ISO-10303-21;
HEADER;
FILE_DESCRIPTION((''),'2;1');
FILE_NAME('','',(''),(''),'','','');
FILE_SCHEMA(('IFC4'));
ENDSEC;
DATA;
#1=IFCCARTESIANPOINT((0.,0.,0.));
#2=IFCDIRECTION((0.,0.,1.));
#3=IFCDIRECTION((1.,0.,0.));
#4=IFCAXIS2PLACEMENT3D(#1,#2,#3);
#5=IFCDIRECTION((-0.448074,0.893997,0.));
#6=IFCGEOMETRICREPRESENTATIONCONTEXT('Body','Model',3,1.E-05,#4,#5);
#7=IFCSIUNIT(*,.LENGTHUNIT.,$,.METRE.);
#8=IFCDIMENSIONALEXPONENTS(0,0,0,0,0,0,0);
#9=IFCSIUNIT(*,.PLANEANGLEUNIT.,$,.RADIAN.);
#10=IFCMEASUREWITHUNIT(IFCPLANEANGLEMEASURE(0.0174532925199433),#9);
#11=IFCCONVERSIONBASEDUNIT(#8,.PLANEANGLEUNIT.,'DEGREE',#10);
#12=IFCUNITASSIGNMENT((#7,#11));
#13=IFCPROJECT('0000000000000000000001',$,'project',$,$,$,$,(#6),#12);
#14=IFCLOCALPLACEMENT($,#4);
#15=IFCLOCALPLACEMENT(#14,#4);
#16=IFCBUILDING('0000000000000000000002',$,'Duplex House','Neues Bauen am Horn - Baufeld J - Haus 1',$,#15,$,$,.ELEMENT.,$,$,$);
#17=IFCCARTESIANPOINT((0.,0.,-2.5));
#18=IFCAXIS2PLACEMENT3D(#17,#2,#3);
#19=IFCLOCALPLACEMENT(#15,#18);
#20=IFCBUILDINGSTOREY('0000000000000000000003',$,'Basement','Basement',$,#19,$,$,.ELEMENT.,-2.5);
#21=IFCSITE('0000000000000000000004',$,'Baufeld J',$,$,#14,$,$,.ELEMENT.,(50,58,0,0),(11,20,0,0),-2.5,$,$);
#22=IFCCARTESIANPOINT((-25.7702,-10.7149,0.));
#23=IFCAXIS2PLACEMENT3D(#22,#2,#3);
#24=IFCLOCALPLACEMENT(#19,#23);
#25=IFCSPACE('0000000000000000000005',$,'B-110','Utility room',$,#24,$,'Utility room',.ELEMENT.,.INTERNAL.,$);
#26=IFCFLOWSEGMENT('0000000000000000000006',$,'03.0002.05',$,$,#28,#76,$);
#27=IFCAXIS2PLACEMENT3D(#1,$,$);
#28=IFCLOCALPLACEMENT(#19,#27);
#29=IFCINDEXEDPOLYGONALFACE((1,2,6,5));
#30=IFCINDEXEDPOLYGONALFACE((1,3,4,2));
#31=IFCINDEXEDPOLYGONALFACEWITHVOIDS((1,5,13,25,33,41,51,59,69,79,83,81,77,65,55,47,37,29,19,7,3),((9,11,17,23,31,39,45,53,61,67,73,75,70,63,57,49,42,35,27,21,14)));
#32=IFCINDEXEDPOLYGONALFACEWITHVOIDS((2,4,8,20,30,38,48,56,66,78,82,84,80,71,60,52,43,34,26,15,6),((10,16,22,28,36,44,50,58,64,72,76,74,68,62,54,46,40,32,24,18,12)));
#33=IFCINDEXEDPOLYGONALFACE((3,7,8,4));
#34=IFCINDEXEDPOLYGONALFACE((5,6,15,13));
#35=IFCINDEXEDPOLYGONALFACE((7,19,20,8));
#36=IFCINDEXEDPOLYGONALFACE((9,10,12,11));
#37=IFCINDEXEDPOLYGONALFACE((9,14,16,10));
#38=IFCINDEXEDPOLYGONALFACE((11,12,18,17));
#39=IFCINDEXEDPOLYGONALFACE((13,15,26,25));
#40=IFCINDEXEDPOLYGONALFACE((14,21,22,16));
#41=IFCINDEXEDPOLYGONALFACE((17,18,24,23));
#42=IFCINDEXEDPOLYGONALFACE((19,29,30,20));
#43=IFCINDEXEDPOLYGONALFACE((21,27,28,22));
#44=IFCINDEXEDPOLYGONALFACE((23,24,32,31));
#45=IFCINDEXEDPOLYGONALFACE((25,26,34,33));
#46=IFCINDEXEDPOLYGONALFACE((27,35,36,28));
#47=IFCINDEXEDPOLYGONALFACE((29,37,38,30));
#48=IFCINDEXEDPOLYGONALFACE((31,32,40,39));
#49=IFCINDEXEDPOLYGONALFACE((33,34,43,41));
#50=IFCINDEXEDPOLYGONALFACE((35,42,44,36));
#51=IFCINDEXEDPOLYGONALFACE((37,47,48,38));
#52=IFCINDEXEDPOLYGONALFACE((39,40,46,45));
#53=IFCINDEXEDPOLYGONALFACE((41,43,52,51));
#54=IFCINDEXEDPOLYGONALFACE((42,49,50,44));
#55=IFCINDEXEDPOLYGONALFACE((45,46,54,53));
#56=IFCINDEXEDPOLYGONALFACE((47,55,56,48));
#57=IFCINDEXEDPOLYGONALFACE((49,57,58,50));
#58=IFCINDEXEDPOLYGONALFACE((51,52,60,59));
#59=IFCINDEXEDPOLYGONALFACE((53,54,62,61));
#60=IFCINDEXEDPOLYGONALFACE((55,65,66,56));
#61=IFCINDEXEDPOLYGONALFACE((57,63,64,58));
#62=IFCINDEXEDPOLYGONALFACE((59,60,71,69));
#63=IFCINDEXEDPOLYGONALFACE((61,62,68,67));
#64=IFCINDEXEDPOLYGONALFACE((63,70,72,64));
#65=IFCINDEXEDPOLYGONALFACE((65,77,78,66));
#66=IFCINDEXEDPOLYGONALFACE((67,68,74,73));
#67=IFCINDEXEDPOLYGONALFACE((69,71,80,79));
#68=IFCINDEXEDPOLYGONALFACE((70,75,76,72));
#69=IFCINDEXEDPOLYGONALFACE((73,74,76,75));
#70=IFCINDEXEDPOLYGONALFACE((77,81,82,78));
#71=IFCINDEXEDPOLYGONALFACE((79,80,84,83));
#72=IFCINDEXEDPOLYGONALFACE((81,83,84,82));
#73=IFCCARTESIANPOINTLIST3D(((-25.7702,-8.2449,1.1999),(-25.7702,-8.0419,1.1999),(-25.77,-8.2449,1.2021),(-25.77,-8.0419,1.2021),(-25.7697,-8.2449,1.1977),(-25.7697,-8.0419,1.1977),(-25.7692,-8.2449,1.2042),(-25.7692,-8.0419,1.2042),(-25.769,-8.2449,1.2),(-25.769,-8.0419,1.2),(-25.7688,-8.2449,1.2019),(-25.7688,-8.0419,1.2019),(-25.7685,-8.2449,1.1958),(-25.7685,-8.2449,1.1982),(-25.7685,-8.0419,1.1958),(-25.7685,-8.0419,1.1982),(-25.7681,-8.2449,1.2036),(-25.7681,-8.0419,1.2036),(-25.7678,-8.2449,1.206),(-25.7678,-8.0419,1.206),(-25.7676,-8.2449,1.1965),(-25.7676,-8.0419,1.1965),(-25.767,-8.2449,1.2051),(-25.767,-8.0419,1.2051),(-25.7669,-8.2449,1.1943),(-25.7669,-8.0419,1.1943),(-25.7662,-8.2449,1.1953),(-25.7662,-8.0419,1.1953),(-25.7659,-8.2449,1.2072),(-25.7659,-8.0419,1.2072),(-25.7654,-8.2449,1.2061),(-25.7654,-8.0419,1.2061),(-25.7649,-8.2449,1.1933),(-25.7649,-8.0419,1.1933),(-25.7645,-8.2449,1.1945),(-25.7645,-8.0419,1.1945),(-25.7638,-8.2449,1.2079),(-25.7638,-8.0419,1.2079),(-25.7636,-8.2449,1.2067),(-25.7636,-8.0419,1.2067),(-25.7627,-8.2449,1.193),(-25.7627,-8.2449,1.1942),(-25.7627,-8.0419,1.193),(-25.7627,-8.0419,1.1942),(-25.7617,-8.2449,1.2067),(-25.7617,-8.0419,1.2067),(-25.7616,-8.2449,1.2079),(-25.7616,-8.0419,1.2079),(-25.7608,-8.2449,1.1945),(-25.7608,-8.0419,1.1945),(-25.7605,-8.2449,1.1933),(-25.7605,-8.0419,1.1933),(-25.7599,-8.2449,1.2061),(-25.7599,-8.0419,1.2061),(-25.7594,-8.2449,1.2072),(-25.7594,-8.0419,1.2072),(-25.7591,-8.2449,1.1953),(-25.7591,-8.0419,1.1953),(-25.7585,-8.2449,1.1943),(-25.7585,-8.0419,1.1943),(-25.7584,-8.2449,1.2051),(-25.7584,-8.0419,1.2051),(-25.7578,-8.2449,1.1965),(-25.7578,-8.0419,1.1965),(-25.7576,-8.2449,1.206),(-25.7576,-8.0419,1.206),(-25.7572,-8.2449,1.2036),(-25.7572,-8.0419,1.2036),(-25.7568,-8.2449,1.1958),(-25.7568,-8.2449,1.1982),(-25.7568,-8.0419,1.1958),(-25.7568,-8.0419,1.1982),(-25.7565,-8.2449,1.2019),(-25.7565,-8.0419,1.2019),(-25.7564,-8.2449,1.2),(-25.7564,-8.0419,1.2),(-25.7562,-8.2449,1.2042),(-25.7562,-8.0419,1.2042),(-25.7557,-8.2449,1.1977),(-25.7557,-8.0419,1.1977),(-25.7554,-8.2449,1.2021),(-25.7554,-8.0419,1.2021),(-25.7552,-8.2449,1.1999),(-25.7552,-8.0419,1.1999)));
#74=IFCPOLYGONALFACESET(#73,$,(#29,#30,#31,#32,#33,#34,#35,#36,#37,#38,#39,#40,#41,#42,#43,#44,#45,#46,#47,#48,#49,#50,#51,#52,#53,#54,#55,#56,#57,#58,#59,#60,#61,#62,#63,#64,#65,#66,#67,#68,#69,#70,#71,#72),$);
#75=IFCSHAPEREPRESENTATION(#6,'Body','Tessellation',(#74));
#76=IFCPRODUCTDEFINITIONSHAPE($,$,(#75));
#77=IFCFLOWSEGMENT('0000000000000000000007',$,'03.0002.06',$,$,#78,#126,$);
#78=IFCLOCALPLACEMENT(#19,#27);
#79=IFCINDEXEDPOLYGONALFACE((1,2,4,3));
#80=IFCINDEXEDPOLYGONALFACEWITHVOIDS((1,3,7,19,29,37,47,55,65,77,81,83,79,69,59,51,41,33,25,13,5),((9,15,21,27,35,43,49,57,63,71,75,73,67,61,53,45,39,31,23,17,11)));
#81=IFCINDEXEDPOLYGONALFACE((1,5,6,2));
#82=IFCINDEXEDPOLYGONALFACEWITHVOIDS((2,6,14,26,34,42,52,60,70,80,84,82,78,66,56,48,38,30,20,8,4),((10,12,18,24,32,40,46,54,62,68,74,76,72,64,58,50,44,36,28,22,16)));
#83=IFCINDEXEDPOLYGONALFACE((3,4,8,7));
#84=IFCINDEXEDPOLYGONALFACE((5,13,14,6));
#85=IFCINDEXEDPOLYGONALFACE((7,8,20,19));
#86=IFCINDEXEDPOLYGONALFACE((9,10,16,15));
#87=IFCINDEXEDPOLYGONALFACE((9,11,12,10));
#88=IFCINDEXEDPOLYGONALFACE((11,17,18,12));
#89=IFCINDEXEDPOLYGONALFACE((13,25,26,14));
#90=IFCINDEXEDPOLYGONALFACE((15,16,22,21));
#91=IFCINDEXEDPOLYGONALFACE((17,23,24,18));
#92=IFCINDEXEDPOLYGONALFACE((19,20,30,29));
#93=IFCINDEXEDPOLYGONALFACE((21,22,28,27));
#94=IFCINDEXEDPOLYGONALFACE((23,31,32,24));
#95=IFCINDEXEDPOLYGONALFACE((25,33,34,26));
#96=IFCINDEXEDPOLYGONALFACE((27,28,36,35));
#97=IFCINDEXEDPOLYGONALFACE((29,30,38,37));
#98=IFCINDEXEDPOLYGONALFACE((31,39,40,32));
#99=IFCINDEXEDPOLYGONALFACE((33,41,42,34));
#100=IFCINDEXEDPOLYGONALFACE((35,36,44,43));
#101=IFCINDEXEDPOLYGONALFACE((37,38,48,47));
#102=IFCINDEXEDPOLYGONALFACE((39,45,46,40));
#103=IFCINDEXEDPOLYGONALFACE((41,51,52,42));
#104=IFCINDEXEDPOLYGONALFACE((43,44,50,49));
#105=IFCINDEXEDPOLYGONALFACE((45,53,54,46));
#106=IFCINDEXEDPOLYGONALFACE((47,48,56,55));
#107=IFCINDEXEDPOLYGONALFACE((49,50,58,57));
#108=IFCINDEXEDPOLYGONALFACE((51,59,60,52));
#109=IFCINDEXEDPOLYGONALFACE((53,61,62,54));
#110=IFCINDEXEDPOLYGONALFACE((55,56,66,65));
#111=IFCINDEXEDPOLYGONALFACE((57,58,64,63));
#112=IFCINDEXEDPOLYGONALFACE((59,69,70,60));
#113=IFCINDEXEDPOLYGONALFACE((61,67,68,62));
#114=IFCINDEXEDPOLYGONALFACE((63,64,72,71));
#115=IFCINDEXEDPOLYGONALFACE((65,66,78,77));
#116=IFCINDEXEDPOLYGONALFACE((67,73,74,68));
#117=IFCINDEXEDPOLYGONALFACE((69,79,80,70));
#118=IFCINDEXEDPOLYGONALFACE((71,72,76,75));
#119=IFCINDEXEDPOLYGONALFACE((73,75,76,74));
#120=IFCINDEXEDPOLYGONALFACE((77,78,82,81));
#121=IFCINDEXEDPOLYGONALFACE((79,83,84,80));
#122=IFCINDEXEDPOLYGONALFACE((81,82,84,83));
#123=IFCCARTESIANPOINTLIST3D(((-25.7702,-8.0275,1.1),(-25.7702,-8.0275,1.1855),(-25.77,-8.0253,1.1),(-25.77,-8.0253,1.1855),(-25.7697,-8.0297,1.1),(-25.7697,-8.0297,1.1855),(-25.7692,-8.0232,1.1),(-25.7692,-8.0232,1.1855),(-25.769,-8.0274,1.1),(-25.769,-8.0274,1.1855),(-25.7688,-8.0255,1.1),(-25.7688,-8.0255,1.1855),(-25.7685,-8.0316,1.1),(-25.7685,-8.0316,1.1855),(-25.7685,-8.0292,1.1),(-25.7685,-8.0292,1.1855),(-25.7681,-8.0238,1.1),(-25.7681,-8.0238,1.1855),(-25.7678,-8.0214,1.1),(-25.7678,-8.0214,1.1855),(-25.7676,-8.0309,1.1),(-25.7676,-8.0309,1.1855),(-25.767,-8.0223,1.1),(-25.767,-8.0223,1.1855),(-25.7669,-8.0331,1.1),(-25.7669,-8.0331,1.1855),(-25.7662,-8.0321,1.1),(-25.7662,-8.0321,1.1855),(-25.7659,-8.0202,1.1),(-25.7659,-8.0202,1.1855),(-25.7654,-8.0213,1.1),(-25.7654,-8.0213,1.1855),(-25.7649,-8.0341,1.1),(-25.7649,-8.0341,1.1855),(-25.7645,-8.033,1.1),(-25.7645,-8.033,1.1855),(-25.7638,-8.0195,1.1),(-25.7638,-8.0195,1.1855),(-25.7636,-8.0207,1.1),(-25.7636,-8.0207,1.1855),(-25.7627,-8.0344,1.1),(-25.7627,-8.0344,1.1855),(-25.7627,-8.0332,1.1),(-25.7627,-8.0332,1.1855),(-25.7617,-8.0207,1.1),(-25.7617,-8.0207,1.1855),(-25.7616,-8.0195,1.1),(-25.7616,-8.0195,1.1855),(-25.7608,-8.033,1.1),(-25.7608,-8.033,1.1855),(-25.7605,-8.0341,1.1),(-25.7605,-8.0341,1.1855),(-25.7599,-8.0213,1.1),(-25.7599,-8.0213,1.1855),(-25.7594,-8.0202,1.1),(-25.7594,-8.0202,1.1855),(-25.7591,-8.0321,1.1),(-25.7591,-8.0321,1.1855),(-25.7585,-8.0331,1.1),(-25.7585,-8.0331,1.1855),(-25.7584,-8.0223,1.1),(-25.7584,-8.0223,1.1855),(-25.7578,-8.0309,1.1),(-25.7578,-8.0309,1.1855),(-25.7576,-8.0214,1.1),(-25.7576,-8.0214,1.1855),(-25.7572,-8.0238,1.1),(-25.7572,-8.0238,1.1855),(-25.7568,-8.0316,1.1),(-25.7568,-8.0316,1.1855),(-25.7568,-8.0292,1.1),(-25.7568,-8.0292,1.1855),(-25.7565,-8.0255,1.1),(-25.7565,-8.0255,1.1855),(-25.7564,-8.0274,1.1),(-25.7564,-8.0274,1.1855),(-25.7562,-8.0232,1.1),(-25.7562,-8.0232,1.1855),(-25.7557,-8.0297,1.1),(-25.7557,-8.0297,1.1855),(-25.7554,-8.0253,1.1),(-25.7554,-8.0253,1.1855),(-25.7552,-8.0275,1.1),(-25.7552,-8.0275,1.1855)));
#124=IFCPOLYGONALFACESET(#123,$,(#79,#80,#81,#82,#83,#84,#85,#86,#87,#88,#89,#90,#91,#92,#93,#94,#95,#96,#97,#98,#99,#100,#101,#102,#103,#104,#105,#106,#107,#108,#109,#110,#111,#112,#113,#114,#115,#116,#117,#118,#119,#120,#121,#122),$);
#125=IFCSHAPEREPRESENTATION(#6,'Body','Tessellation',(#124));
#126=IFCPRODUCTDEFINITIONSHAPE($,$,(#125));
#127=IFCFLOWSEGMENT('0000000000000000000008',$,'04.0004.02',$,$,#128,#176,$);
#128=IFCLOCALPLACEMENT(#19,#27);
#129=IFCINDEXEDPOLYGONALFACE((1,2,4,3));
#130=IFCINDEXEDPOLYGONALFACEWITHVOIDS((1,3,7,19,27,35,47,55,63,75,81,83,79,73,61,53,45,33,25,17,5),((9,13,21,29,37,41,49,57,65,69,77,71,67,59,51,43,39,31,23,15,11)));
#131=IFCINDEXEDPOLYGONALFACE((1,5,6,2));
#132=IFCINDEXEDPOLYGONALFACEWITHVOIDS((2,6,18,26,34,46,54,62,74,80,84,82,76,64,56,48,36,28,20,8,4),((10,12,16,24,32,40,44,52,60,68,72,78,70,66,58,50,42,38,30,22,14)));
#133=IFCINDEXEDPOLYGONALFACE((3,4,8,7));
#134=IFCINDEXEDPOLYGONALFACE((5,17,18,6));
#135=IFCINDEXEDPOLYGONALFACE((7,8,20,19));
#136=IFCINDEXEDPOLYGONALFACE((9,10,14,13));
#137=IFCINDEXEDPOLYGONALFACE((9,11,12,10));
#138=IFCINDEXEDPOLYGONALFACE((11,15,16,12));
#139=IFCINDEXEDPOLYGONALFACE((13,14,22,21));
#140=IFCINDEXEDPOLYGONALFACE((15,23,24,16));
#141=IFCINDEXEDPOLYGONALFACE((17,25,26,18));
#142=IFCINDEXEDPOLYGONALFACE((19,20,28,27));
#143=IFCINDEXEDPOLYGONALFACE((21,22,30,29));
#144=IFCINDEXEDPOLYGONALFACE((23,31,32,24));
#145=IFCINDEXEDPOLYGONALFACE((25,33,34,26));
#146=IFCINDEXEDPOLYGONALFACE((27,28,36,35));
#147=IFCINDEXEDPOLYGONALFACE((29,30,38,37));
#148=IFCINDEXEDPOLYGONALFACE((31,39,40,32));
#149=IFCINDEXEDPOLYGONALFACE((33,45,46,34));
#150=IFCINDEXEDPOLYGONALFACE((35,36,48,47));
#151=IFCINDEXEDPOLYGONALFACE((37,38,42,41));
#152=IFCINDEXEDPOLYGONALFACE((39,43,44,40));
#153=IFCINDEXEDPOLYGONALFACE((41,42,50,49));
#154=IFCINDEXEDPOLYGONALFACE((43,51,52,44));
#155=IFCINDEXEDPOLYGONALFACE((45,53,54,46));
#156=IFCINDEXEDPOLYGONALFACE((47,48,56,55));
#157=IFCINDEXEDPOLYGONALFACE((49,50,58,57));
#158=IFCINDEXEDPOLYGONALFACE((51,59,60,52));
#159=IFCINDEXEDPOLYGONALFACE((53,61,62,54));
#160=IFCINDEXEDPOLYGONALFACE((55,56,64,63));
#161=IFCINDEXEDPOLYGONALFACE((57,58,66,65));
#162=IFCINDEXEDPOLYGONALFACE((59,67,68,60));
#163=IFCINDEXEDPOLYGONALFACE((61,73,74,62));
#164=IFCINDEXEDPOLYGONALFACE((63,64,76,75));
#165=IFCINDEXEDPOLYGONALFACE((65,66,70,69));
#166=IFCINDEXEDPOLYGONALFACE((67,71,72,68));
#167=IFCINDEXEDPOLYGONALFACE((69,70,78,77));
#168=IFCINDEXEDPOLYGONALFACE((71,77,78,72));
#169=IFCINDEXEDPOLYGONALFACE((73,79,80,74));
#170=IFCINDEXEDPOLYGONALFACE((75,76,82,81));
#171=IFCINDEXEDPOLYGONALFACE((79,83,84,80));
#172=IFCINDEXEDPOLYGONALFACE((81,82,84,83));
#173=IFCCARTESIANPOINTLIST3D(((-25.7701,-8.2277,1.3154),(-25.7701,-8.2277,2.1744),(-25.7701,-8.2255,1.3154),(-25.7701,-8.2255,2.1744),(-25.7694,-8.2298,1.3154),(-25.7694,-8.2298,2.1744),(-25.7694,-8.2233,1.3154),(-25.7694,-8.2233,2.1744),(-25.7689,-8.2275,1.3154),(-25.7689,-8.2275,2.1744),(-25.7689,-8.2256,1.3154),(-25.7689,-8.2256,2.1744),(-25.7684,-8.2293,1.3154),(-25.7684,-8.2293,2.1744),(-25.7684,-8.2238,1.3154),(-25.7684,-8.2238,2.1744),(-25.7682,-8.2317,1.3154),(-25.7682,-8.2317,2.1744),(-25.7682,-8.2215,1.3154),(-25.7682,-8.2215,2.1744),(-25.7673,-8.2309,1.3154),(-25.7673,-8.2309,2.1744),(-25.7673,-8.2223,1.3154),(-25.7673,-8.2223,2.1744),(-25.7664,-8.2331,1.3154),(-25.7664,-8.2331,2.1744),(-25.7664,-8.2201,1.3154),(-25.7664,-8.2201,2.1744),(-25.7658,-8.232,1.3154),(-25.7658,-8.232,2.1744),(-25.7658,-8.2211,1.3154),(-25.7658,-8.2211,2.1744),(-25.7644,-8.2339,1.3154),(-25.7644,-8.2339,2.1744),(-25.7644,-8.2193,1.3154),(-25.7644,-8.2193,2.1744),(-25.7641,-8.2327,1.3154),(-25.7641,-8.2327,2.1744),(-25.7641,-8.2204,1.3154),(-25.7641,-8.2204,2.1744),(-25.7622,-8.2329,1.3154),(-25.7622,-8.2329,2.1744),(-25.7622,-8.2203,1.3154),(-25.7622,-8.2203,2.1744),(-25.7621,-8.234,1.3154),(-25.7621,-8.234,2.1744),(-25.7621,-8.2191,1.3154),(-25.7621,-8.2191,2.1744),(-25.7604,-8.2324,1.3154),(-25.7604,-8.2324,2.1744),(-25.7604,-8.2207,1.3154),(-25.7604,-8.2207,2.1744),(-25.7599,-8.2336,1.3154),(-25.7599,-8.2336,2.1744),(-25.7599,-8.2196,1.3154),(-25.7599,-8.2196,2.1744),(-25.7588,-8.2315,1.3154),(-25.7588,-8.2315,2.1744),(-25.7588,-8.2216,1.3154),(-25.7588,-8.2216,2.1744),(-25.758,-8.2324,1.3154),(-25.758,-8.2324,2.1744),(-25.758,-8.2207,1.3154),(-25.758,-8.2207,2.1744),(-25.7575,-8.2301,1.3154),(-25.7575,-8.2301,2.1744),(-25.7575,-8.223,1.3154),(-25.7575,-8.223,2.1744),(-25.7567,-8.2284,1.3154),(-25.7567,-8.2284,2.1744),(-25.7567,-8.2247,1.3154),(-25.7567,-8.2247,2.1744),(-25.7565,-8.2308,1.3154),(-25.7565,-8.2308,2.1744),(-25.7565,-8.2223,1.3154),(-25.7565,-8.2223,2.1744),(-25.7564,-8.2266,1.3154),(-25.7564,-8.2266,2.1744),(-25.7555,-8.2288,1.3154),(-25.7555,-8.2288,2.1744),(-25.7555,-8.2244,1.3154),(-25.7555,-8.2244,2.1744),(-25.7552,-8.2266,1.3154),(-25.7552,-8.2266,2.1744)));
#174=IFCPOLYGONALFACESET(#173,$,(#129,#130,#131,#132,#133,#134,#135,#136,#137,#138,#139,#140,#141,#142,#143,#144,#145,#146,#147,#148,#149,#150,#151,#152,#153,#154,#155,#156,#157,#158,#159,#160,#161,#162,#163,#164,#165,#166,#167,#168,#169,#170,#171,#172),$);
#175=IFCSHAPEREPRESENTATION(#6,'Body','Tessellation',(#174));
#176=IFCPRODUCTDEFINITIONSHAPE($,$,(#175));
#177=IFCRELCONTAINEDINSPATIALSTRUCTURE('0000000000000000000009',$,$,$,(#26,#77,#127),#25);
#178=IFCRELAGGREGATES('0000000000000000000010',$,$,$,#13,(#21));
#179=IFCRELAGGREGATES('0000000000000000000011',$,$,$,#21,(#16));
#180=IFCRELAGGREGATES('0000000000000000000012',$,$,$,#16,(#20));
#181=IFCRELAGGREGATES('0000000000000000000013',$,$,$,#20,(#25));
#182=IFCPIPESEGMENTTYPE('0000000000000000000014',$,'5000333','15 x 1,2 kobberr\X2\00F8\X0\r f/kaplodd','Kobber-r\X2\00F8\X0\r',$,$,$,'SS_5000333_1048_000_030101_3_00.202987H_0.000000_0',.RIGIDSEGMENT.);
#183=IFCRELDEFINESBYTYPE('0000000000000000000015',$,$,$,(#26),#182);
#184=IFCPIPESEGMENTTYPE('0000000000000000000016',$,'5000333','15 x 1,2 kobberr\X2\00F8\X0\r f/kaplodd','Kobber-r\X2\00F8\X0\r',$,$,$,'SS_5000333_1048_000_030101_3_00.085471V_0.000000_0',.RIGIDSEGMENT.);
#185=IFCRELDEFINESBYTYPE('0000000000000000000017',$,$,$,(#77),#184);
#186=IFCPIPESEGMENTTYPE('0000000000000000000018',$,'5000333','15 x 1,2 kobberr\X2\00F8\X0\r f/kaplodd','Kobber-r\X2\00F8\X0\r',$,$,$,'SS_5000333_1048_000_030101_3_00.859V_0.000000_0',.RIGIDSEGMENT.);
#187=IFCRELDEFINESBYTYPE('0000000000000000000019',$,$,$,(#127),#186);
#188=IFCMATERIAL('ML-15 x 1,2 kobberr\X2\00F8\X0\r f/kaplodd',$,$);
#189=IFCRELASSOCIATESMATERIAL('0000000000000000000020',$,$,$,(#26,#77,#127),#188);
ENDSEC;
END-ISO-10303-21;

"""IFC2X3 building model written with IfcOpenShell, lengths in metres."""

from ifc_helpers import new_model, entity, si_unit, converted_unit, direction, frame, origin_with_axes, origin_2d_with_axis, place, context, project, spatial, hollow_circle, extrude, material, type_object, element, save


model = new_model("IFC2X3")

# Units and contexts
model_context = context("Model", 3, precision=1e-05, world=origin_with_axes(), true_north=direction((-0.448074, 0.893997, 0.0)), identifier="Body")
ifc_project = project(units=[si_unit("LENGTHUNIT", "METRE"), converted_unit("PLANEANGLEUNIT", "DEGREE", entity("IfcPlaneAngleMeasure", 0.0174532925199433), si_unit("PLANEANGLEUNIT", "RADIAN"), dimensions=[0, 0, 0, 0, 0, 0, 0])], contexts=[model_context])

# Site, building, storey, space
site_placement = place(None, origin_with_axes())
site = spatial("IfcSite", under=ifc_project, at=site_placement, Name="Baufeld J", CompositionType="ELEMENT", RefLatitude=(50, 58, 0, 0), RefLongitude=(11, 20, 0, 0), RefElevation=-2.5)
building_placement = place(site_placement, origin_with_axes())
building = spatial("IfcBuilding", under=site, at=building_placement, Name="Duplex House", Description="Neues Bauen am Horn - Baufeld J - Haus 1", CompositionType="ELEMENT")
storey_placement = place(building_placement, frame((0.0, 0.0, -2.5), z_axis=(0.0, 0.0, 1.0), x_axis=(1.0, 0.0, 0.0)))
storey = spatial("IfcBuildingStorey", under=building, at=storey_placement, Name="Basement", Description="Basement", CompositionType="ELEMENT", Elevation=-2.5)
space_1_placement = place(storey_placement, frame((-25.7702, -10.7149, 0.0), z_axis=(0.0, 0.0, 1.0), x_axis=(1.0, 0.0, 0.0)))
space_1 = spatial("IfcSpace", under=storey, at=space_1_placement, Name="B-110", Description="Utility room", LongName="Utility room", CompositionType="ELEMENT", InteriorOrExteriorSpace="INTERNAL")

# Shared definitions
ifc_material_1 = material(Name="ML-15 x 1,2 kobberrør f/kaplodd")

# Flow segments
pipe_segment_type_1 = type_object("IfcPipeSegmentType", Name="5000333", Description="15 x 1,2 kobberrør f/kaplodd", ApplicableOccurrence="Kobber-rør", ElementType="SS_5000333_1048_000_030101_3_00.202987H_0.000000_0", PredefinedType="RIGIDSEGMENT")
flow_segment_1_placement = place(space_1_placement, frame((0.0075, 2.47, 1.2005), z_axis=(0.0, 0.0, 1.0), x_axis=(0.0, 1.0, 0.0)))
element("IfcFlowSegment", 1, at=flow_segment_1_placement, inside=space_1, type_object=pipe_segment_type_1, material=ifc_material_1, Name="03.0002.05", context=model_context, shape_type="SweptSolid", body=[
    extrude(hollow_circle(Radius=0.0075, WallThickness=0.0012, at=origin_2d_with_axis()), frame((0.0, 0.0, 0.0), z_axis=(1.0, 0.0, 0.0), x_axis=(0.0, 0.0, -1.0)), (0.0, 0.0, 1.0), 0.203),
])
pipe_segment_type_2 = type_object("IfcPipeSegmentType", Name="5000333", Description="15 x 1,2 kobberrør f/kaplodd", ApplicableOccurrence="Kobber-rør", ElementType="SS_5000333_1048_000_030101_3_00.085471V_0.000000_0", PredefinedType="RIGIDSEGMENT")
flow_segment_2_placement = place(space_1_placement, frame((0.0075, 2.688, 1.1855), z_axis=(0.0, 1.0, 0.0), x_axis=(0.0, 0.0, -1.0)))
element("IfcFlowSegment", 2, at=flow_segment_2_placement, inside=space_1, type_object=pipe_segment_type_2, material=ifc_material_1, Name="03.0002.06", context=model_context, shape_type="SweptSolid", body=[
    extrude(hollow_circle(Radius=0.0075, WallThickness=0.0012, at=origin_2d_with_axis()), frame((0.0, 0.0, 0.0), z_axis=(1.0, 0.0, 0.0), x_axis=(0.0, 0.0, -1.0)), (0.0, 0.0, 1.0), 0.0855),
])
pipe_segment_type_3 = type_object("IfcPipeSegmentType", Name="5000333", Description="15 x 1,2 kobberrør f/kaplodd", ApplicableOccurrence="Kobber-rør", ElementType="SS_5000333_1048_000_030101_3_00.859V_0.000000_0", PredefinedType="RIGIDSEGMENT")
flow_segment_3_placement = place(space_1_placement, frame((0.0075, 2.4884, 2.1744), z_axis=(-1.0, 0.0, 0.0), x_axis=(0.0, 0.0, -1.0)))
element("IfcFlowSegment", 3, at=flow_segment_3_placement, inside=space_1, type_object=pipe_segment_type_3, material=ifc_material_1, Name="04.0004.02", context=model_context, shape_type="SweptSolid", body=[
    extrude(hollow_circle(Radius=0.0075, WallThickness=0.0012, at=origin_2d_with_axis()), frame((0.0, 0.0, 0.0), z_axis=(1.0, 0.0, 0.0), x_axis=(0.0, 0.0, -1.0)), (0.0, 0.0, 1.0), 0.859),
])

save(model, "model.ifc")
